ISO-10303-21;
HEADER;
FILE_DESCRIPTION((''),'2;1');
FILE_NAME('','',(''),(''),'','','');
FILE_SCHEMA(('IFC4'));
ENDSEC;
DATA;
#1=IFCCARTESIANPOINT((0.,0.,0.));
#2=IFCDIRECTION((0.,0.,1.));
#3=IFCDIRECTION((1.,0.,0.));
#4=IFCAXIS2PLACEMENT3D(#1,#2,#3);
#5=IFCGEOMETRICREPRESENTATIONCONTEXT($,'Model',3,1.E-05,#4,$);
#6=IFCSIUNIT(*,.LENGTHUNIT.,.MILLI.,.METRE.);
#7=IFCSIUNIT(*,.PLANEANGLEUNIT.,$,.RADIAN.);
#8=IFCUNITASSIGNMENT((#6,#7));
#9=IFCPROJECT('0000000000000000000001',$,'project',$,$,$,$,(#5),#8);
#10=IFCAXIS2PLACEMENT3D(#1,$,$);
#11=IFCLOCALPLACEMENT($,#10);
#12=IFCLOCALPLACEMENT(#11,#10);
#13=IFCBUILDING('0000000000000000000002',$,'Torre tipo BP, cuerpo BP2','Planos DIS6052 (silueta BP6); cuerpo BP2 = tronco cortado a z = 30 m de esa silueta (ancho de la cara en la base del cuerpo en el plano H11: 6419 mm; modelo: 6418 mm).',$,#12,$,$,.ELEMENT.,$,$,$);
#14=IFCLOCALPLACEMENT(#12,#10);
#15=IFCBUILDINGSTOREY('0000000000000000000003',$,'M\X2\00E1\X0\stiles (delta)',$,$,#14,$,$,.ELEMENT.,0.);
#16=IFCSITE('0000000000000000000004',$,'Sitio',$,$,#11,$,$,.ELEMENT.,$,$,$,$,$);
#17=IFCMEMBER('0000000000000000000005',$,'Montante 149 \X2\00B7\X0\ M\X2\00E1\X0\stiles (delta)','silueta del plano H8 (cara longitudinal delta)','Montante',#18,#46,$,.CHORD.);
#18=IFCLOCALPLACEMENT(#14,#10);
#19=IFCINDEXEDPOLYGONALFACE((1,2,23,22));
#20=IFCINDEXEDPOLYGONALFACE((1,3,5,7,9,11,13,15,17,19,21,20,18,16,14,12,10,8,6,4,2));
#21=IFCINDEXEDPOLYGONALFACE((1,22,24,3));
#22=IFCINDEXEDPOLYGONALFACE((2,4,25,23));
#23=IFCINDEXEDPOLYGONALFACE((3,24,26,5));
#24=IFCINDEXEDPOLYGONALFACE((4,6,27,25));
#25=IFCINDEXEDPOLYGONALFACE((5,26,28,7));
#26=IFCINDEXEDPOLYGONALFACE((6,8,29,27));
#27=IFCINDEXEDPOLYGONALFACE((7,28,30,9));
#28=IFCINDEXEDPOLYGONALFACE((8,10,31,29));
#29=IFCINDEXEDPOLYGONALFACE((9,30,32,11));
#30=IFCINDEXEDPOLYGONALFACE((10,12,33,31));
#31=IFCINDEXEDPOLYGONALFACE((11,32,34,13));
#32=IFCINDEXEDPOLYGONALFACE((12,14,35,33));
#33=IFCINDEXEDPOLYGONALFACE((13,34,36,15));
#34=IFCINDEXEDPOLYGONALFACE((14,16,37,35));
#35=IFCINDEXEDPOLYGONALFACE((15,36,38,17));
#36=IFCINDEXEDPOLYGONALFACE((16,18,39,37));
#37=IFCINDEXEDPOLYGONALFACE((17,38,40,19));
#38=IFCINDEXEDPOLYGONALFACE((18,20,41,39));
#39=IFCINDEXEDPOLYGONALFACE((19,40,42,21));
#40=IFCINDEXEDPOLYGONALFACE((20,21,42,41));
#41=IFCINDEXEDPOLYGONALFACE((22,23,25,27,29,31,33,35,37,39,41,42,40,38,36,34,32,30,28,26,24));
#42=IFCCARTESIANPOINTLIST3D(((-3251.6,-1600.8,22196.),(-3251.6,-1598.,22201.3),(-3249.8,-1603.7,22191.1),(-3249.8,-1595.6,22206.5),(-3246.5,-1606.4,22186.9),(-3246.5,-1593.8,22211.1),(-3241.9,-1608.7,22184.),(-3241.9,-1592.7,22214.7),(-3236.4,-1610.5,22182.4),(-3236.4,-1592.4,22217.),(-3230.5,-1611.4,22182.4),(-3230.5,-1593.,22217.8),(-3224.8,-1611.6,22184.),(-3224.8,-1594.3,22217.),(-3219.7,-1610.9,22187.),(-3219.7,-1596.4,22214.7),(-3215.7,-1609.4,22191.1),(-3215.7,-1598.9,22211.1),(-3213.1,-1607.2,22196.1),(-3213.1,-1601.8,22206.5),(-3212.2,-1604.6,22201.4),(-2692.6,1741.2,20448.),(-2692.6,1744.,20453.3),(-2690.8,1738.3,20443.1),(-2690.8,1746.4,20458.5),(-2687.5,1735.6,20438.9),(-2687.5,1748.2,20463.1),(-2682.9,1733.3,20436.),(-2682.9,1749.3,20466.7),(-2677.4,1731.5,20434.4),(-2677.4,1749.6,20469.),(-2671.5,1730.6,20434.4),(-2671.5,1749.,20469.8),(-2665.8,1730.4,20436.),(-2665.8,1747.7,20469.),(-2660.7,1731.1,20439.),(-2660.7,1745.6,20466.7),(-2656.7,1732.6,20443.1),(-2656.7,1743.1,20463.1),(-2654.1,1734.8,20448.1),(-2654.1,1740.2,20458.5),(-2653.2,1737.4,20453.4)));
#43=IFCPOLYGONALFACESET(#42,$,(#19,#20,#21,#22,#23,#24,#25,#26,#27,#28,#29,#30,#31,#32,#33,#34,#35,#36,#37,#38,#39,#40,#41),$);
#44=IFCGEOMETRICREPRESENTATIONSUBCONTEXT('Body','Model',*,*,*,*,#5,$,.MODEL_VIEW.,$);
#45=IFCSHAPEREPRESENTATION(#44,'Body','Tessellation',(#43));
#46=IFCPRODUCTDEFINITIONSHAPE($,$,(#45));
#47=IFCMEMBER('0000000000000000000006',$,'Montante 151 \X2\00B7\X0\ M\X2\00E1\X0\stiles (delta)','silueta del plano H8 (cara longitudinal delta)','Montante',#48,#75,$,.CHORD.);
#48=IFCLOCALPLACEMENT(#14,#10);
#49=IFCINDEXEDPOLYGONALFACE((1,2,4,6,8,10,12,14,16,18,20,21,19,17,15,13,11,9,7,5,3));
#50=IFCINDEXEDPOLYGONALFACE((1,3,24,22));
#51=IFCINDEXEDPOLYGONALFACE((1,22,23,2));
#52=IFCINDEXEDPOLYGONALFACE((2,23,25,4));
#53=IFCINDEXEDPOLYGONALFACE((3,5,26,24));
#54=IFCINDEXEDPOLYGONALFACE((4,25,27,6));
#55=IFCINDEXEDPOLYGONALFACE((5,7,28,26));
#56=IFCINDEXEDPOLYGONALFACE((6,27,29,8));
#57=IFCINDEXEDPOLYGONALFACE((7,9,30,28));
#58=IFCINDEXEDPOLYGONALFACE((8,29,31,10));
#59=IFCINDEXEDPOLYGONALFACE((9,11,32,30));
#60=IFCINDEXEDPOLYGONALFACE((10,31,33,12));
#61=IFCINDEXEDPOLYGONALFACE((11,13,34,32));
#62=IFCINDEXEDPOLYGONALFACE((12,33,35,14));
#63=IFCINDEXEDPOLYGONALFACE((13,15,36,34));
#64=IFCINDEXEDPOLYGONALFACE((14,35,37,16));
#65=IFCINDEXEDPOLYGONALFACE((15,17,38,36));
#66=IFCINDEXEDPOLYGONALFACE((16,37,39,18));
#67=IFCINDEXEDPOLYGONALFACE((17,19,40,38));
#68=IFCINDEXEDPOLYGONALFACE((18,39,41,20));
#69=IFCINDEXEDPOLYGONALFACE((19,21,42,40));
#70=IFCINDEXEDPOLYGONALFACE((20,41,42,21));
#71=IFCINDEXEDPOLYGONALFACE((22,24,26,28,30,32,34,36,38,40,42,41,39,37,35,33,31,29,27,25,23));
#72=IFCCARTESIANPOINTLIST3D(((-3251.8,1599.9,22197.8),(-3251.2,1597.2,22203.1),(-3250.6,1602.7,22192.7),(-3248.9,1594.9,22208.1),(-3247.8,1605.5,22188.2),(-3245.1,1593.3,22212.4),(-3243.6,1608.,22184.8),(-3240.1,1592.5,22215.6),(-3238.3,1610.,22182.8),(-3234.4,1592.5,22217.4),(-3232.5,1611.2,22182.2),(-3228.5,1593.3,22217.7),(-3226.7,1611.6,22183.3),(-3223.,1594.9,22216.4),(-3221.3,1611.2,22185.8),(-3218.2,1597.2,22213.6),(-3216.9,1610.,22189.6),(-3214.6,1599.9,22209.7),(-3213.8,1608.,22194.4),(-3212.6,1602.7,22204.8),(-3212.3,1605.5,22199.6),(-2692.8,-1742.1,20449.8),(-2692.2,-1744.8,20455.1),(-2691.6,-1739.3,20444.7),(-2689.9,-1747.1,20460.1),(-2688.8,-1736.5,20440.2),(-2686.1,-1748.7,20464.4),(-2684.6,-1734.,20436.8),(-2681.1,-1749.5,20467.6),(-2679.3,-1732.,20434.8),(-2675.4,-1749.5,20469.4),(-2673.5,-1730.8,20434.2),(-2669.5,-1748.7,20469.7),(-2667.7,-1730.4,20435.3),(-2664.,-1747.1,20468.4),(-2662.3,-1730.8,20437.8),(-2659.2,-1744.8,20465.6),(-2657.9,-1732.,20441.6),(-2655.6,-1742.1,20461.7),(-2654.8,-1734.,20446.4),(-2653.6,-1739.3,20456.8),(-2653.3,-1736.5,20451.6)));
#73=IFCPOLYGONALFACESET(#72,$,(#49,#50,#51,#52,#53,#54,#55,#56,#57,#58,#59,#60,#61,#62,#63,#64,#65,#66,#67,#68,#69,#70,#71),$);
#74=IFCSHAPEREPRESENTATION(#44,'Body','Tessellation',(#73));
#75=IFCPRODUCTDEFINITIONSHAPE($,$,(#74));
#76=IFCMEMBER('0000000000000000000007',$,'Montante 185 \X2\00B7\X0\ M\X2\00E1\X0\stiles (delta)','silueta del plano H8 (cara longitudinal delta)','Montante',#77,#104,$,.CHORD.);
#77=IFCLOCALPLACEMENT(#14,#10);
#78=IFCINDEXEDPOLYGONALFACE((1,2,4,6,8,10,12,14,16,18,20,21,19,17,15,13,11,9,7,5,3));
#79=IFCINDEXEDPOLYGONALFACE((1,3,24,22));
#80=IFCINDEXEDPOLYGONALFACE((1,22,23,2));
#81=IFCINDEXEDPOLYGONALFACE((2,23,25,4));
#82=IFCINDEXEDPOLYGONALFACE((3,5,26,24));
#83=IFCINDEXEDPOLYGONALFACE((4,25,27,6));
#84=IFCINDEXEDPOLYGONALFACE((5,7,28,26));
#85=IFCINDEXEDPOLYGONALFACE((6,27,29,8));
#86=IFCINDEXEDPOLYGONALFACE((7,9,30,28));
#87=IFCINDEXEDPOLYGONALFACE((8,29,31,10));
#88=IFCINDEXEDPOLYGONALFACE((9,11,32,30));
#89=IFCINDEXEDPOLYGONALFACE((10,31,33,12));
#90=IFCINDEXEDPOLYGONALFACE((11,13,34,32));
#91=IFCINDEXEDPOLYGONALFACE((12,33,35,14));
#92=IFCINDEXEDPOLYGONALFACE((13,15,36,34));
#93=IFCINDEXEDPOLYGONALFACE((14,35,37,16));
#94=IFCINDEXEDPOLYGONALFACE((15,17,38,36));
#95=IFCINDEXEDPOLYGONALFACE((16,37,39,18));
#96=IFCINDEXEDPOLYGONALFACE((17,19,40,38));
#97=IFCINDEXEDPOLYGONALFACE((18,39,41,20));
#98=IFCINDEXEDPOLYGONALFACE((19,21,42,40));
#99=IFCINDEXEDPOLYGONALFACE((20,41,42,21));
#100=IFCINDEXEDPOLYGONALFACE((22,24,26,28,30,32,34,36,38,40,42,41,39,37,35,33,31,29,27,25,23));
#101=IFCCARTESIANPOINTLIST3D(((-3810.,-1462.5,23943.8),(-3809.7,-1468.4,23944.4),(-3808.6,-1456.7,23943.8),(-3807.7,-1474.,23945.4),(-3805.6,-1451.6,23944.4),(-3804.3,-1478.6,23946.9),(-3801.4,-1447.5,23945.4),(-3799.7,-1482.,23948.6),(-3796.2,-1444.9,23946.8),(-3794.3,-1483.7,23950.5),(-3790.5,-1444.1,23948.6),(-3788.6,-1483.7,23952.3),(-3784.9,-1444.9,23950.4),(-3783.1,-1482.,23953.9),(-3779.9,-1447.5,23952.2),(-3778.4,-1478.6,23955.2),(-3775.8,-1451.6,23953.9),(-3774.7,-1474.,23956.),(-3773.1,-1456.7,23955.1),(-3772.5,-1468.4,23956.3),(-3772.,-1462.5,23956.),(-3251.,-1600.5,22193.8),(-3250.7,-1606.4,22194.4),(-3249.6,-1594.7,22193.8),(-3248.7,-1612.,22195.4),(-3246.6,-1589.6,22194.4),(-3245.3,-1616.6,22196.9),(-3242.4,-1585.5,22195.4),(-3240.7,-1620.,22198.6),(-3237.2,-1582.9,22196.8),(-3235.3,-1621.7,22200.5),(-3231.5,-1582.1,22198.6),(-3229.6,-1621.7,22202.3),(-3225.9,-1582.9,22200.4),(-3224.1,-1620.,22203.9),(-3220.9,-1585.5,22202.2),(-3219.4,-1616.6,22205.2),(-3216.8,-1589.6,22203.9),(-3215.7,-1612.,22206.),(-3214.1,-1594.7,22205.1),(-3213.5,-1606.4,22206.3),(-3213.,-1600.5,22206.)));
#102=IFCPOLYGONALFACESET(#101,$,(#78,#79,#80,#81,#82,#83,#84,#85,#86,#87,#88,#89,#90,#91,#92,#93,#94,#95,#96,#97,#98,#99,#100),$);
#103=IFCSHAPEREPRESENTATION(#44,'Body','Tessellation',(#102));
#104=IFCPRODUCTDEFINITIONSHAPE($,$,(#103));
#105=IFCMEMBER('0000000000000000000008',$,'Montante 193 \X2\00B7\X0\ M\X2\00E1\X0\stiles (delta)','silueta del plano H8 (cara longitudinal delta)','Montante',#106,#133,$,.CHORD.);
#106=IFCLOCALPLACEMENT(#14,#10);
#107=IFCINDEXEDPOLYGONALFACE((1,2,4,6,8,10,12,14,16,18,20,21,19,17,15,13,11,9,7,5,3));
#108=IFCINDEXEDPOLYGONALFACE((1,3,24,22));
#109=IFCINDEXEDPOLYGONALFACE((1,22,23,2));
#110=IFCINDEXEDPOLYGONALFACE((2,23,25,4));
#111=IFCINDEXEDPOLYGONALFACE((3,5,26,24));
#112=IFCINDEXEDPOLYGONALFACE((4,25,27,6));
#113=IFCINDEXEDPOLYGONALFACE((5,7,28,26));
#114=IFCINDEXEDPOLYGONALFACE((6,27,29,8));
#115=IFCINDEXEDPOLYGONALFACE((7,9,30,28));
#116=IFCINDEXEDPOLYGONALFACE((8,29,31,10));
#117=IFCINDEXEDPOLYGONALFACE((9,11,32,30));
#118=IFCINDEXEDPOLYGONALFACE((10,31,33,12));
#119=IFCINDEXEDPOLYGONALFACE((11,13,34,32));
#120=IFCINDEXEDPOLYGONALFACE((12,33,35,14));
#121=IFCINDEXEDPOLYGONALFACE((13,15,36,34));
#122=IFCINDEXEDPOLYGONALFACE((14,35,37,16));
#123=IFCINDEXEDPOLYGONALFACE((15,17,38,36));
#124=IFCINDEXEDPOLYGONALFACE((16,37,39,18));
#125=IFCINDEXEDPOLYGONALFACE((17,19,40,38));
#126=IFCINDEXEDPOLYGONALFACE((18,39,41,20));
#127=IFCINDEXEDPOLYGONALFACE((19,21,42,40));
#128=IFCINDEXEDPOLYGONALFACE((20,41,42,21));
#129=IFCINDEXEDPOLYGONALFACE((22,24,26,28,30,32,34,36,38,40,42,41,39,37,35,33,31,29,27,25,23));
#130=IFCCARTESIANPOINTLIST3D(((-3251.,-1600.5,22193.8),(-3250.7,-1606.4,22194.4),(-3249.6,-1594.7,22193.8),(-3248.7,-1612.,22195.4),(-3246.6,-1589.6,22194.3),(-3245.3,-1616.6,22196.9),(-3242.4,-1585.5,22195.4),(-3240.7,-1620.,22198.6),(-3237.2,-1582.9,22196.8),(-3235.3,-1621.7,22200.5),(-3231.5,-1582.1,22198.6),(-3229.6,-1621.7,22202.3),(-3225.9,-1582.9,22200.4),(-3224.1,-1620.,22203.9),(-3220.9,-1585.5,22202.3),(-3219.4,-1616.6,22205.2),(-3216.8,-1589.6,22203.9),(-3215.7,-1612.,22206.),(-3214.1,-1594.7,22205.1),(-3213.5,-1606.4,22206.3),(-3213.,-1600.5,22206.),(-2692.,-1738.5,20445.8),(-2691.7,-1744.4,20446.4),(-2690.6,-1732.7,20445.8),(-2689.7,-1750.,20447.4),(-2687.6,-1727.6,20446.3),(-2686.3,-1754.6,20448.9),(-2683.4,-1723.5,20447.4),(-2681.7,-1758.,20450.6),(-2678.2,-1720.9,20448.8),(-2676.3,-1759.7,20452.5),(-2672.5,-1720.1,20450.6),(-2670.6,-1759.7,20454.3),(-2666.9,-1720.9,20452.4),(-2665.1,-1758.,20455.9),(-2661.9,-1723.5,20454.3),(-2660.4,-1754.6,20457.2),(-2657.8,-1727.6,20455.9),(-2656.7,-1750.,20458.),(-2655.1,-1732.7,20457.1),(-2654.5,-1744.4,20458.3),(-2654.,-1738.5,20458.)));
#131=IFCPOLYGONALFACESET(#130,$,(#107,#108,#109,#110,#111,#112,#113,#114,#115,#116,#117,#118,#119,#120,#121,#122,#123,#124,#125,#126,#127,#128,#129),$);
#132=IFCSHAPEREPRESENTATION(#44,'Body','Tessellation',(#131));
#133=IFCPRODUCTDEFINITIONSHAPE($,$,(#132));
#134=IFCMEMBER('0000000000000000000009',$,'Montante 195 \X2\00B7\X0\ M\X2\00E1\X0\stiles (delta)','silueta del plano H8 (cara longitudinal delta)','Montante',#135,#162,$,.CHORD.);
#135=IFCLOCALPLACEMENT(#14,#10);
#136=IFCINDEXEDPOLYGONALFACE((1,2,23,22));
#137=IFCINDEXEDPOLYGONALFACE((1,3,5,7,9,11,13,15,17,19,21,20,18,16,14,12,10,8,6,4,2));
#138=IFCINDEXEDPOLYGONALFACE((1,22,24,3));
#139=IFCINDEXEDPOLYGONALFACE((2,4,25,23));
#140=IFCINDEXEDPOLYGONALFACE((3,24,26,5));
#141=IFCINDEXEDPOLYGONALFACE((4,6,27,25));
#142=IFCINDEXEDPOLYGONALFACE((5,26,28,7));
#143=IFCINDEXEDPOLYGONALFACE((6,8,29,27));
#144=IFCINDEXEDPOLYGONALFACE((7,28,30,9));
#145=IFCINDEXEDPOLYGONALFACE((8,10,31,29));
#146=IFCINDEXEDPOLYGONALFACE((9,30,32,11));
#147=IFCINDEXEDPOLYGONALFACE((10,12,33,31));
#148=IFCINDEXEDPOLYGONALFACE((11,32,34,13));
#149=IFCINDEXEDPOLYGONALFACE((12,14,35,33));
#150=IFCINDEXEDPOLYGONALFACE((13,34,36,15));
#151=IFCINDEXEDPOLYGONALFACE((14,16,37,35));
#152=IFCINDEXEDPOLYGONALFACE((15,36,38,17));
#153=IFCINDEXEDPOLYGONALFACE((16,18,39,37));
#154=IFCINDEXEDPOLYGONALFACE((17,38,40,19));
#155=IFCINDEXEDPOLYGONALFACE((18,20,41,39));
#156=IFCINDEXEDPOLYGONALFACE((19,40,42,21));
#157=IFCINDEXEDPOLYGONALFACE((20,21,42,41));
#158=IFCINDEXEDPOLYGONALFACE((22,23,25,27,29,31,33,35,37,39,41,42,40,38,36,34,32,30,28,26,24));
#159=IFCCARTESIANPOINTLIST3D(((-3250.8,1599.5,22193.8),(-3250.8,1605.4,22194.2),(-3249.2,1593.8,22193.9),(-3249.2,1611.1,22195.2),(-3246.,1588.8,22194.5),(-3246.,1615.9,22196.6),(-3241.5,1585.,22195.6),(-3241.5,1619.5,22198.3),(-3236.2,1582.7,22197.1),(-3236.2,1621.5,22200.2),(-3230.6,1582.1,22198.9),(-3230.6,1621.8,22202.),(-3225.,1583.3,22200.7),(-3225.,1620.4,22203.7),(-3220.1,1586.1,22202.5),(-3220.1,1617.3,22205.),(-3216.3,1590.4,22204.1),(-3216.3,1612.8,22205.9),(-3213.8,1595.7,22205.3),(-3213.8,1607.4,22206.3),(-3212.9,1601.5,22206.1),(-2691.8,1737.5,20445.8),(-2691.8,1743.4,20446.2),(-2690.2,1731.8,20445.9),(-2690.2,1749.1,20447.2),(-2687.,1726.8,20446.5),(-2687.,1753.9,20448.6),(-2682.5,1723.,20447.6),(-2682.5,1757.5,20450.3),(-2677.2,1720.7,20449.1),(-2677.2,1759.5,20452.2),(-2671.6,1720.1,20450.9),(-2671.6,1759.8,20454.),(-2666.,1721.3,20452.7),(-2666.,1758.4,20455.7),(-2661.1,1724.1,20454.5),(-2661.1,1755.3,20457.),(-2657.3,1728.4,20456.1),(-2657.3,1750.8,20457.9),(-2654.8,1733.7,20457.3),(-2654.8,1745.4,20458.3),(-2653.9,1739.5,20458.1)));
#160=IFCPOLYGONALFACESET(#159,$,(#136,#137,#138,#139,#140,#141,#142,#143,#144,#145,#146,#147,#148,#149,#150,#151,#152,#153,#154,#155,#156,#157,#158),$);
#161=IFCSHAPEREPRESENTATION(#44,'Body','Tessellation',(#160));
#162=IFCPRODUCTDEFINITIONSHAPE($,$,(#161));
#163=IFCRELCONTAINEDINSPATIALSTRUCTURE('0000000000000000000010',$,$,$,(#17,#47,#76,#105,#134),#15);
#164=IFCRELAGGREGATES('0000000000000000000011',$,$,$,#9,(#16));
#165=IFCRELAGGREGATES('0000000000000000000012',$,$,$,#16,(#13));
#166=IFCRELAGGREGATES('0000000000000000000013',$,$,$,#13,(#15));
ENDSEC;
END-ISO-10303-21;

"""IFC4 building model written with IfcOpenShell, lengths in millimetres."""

from ifc_helpers import new_model, si_unit, frame, origin, origin_with_axes, place, context, subcontext, project, spatial, circle, extrude, element, save


model = new_model("IFC4")

# Units and contexts
model_context = context("Model", 3, precision=1e-05, world=origin_with_axes())
body_context = subcontext(model_context, "Body", "Model", "MODEL_VIEW")
ifc_project = project(units=[si_unit("LENGTHUNIT", "METRE", prefix="MILLI"), si_unit("PLANEANGLEUNIT", "RADIAN")], contexts=[model_context])

# Site, building, storey
site_placement = place(None, origin())
site = spatial("IfcSite", under=ifc_project, at=site_placement, Name="Sitio", CompositionType="ELEMENT")
building_placement = place(site_placement, origin())
building = spatial("IfcBuilding", under=site, at=building_placement, Name="Torre tipo BP, cuerpo BP2", Description="Planos DIS6052 (silueta BP6); cuerpo BP2 = tronco cortado a z = 30 m de esa silueta (ancho de la cara en la base del cuerpo en el plano H11: 6419 mm; modelo: 6418 mm).", CompositionType="ELEMENT")
storey_placement = place(building_placement, origin())
storey = spatial("IfcBuildingStorey", under=building, at=storey_placement, Name="Mástiles (delta)", CompositionType="ELEMENT", Elevation=0.0)

# Members
for number, where, z_axis, x_axis, name in (
    (1, (-3232.0, -1602.0, 22200.0), (0.146614, 0.876536, -0.458464), (0.989194, -0.129916, 0.067951), "Montante 149 · Mástiles (delta)"),
    (2, (-3232.0, 1602.0, 22200.0), (0.146614, -0.876536, -0.458464), (0.266991, 0.481336, -0.834884), "Montante 151 · Mástiles (delta)"),
):
    element("IfcMember", number, at=place(storey_placement, frame(where, z_axis=z_axis, x_axis=x_axis)), inside=storey, Name=name, Description="silueta del plano H8 (cara longitudinal delta)", ObjectType="Montante", PredefinedType="CHORD", context=body_context, shape_type="SweptSolid", body=[
        extrude(circle(Radius=20.0), None, (0.0, 0.0, 1.0), 3812.7),
    ])
member_placement = place(storey_placement, frame((-3791.0, -1464.0, 23950.0), z_axis=(0.303427, -0.074907, -0.949906), x_axis=(0.022793, 0.997191, -0.071355)))
element("IfcMember", 3, at=member_placement, inside=storey, Name="Montante 185 · Mástiles (delta)", Description="silueta del plano H8 (cara longitudinal delta)", ObjectType="Montante", PredefinedType="CHORD", context=body_context, shape_type="SweptSolid", body=[
    extrude(circle(Radius=20.0), None, (0.0, 0.0, 1.0), 1842.3),
])
for number, where, z_axis, x_axis, name in (
    (4, (-3232.0, -1602.0, 22200.0), (0.30374, -0.074984, -0.9498), (0.02284, 0.997185, -0.071421), "Montante 193 · Mástiles (delta)"),
    (5, (-3232.0, 1602.0, 22200.0), (0.30374, 0.074984, -0.9498), (0.952755, -0.023905, 0.302798), "Montante 195 · Mástiles (delta)"),
):
    element("IfcMember", number, at=place(storey_placement, frame(where, z_axis=z_axis, x_axis=x_axis)), inside=storey, Name=name, Description="silueta del plano H8 (cara longitudinal delta)", ObjectType="Montante", PredefinedType="CHORD", context=body_context, shape_type="SweptSolid", body=[
        extrude(circle(Radius=20.0), None, (0.0, 0.0, 1.0), 1840.4),
    ])

save(model, "model.ifc")
